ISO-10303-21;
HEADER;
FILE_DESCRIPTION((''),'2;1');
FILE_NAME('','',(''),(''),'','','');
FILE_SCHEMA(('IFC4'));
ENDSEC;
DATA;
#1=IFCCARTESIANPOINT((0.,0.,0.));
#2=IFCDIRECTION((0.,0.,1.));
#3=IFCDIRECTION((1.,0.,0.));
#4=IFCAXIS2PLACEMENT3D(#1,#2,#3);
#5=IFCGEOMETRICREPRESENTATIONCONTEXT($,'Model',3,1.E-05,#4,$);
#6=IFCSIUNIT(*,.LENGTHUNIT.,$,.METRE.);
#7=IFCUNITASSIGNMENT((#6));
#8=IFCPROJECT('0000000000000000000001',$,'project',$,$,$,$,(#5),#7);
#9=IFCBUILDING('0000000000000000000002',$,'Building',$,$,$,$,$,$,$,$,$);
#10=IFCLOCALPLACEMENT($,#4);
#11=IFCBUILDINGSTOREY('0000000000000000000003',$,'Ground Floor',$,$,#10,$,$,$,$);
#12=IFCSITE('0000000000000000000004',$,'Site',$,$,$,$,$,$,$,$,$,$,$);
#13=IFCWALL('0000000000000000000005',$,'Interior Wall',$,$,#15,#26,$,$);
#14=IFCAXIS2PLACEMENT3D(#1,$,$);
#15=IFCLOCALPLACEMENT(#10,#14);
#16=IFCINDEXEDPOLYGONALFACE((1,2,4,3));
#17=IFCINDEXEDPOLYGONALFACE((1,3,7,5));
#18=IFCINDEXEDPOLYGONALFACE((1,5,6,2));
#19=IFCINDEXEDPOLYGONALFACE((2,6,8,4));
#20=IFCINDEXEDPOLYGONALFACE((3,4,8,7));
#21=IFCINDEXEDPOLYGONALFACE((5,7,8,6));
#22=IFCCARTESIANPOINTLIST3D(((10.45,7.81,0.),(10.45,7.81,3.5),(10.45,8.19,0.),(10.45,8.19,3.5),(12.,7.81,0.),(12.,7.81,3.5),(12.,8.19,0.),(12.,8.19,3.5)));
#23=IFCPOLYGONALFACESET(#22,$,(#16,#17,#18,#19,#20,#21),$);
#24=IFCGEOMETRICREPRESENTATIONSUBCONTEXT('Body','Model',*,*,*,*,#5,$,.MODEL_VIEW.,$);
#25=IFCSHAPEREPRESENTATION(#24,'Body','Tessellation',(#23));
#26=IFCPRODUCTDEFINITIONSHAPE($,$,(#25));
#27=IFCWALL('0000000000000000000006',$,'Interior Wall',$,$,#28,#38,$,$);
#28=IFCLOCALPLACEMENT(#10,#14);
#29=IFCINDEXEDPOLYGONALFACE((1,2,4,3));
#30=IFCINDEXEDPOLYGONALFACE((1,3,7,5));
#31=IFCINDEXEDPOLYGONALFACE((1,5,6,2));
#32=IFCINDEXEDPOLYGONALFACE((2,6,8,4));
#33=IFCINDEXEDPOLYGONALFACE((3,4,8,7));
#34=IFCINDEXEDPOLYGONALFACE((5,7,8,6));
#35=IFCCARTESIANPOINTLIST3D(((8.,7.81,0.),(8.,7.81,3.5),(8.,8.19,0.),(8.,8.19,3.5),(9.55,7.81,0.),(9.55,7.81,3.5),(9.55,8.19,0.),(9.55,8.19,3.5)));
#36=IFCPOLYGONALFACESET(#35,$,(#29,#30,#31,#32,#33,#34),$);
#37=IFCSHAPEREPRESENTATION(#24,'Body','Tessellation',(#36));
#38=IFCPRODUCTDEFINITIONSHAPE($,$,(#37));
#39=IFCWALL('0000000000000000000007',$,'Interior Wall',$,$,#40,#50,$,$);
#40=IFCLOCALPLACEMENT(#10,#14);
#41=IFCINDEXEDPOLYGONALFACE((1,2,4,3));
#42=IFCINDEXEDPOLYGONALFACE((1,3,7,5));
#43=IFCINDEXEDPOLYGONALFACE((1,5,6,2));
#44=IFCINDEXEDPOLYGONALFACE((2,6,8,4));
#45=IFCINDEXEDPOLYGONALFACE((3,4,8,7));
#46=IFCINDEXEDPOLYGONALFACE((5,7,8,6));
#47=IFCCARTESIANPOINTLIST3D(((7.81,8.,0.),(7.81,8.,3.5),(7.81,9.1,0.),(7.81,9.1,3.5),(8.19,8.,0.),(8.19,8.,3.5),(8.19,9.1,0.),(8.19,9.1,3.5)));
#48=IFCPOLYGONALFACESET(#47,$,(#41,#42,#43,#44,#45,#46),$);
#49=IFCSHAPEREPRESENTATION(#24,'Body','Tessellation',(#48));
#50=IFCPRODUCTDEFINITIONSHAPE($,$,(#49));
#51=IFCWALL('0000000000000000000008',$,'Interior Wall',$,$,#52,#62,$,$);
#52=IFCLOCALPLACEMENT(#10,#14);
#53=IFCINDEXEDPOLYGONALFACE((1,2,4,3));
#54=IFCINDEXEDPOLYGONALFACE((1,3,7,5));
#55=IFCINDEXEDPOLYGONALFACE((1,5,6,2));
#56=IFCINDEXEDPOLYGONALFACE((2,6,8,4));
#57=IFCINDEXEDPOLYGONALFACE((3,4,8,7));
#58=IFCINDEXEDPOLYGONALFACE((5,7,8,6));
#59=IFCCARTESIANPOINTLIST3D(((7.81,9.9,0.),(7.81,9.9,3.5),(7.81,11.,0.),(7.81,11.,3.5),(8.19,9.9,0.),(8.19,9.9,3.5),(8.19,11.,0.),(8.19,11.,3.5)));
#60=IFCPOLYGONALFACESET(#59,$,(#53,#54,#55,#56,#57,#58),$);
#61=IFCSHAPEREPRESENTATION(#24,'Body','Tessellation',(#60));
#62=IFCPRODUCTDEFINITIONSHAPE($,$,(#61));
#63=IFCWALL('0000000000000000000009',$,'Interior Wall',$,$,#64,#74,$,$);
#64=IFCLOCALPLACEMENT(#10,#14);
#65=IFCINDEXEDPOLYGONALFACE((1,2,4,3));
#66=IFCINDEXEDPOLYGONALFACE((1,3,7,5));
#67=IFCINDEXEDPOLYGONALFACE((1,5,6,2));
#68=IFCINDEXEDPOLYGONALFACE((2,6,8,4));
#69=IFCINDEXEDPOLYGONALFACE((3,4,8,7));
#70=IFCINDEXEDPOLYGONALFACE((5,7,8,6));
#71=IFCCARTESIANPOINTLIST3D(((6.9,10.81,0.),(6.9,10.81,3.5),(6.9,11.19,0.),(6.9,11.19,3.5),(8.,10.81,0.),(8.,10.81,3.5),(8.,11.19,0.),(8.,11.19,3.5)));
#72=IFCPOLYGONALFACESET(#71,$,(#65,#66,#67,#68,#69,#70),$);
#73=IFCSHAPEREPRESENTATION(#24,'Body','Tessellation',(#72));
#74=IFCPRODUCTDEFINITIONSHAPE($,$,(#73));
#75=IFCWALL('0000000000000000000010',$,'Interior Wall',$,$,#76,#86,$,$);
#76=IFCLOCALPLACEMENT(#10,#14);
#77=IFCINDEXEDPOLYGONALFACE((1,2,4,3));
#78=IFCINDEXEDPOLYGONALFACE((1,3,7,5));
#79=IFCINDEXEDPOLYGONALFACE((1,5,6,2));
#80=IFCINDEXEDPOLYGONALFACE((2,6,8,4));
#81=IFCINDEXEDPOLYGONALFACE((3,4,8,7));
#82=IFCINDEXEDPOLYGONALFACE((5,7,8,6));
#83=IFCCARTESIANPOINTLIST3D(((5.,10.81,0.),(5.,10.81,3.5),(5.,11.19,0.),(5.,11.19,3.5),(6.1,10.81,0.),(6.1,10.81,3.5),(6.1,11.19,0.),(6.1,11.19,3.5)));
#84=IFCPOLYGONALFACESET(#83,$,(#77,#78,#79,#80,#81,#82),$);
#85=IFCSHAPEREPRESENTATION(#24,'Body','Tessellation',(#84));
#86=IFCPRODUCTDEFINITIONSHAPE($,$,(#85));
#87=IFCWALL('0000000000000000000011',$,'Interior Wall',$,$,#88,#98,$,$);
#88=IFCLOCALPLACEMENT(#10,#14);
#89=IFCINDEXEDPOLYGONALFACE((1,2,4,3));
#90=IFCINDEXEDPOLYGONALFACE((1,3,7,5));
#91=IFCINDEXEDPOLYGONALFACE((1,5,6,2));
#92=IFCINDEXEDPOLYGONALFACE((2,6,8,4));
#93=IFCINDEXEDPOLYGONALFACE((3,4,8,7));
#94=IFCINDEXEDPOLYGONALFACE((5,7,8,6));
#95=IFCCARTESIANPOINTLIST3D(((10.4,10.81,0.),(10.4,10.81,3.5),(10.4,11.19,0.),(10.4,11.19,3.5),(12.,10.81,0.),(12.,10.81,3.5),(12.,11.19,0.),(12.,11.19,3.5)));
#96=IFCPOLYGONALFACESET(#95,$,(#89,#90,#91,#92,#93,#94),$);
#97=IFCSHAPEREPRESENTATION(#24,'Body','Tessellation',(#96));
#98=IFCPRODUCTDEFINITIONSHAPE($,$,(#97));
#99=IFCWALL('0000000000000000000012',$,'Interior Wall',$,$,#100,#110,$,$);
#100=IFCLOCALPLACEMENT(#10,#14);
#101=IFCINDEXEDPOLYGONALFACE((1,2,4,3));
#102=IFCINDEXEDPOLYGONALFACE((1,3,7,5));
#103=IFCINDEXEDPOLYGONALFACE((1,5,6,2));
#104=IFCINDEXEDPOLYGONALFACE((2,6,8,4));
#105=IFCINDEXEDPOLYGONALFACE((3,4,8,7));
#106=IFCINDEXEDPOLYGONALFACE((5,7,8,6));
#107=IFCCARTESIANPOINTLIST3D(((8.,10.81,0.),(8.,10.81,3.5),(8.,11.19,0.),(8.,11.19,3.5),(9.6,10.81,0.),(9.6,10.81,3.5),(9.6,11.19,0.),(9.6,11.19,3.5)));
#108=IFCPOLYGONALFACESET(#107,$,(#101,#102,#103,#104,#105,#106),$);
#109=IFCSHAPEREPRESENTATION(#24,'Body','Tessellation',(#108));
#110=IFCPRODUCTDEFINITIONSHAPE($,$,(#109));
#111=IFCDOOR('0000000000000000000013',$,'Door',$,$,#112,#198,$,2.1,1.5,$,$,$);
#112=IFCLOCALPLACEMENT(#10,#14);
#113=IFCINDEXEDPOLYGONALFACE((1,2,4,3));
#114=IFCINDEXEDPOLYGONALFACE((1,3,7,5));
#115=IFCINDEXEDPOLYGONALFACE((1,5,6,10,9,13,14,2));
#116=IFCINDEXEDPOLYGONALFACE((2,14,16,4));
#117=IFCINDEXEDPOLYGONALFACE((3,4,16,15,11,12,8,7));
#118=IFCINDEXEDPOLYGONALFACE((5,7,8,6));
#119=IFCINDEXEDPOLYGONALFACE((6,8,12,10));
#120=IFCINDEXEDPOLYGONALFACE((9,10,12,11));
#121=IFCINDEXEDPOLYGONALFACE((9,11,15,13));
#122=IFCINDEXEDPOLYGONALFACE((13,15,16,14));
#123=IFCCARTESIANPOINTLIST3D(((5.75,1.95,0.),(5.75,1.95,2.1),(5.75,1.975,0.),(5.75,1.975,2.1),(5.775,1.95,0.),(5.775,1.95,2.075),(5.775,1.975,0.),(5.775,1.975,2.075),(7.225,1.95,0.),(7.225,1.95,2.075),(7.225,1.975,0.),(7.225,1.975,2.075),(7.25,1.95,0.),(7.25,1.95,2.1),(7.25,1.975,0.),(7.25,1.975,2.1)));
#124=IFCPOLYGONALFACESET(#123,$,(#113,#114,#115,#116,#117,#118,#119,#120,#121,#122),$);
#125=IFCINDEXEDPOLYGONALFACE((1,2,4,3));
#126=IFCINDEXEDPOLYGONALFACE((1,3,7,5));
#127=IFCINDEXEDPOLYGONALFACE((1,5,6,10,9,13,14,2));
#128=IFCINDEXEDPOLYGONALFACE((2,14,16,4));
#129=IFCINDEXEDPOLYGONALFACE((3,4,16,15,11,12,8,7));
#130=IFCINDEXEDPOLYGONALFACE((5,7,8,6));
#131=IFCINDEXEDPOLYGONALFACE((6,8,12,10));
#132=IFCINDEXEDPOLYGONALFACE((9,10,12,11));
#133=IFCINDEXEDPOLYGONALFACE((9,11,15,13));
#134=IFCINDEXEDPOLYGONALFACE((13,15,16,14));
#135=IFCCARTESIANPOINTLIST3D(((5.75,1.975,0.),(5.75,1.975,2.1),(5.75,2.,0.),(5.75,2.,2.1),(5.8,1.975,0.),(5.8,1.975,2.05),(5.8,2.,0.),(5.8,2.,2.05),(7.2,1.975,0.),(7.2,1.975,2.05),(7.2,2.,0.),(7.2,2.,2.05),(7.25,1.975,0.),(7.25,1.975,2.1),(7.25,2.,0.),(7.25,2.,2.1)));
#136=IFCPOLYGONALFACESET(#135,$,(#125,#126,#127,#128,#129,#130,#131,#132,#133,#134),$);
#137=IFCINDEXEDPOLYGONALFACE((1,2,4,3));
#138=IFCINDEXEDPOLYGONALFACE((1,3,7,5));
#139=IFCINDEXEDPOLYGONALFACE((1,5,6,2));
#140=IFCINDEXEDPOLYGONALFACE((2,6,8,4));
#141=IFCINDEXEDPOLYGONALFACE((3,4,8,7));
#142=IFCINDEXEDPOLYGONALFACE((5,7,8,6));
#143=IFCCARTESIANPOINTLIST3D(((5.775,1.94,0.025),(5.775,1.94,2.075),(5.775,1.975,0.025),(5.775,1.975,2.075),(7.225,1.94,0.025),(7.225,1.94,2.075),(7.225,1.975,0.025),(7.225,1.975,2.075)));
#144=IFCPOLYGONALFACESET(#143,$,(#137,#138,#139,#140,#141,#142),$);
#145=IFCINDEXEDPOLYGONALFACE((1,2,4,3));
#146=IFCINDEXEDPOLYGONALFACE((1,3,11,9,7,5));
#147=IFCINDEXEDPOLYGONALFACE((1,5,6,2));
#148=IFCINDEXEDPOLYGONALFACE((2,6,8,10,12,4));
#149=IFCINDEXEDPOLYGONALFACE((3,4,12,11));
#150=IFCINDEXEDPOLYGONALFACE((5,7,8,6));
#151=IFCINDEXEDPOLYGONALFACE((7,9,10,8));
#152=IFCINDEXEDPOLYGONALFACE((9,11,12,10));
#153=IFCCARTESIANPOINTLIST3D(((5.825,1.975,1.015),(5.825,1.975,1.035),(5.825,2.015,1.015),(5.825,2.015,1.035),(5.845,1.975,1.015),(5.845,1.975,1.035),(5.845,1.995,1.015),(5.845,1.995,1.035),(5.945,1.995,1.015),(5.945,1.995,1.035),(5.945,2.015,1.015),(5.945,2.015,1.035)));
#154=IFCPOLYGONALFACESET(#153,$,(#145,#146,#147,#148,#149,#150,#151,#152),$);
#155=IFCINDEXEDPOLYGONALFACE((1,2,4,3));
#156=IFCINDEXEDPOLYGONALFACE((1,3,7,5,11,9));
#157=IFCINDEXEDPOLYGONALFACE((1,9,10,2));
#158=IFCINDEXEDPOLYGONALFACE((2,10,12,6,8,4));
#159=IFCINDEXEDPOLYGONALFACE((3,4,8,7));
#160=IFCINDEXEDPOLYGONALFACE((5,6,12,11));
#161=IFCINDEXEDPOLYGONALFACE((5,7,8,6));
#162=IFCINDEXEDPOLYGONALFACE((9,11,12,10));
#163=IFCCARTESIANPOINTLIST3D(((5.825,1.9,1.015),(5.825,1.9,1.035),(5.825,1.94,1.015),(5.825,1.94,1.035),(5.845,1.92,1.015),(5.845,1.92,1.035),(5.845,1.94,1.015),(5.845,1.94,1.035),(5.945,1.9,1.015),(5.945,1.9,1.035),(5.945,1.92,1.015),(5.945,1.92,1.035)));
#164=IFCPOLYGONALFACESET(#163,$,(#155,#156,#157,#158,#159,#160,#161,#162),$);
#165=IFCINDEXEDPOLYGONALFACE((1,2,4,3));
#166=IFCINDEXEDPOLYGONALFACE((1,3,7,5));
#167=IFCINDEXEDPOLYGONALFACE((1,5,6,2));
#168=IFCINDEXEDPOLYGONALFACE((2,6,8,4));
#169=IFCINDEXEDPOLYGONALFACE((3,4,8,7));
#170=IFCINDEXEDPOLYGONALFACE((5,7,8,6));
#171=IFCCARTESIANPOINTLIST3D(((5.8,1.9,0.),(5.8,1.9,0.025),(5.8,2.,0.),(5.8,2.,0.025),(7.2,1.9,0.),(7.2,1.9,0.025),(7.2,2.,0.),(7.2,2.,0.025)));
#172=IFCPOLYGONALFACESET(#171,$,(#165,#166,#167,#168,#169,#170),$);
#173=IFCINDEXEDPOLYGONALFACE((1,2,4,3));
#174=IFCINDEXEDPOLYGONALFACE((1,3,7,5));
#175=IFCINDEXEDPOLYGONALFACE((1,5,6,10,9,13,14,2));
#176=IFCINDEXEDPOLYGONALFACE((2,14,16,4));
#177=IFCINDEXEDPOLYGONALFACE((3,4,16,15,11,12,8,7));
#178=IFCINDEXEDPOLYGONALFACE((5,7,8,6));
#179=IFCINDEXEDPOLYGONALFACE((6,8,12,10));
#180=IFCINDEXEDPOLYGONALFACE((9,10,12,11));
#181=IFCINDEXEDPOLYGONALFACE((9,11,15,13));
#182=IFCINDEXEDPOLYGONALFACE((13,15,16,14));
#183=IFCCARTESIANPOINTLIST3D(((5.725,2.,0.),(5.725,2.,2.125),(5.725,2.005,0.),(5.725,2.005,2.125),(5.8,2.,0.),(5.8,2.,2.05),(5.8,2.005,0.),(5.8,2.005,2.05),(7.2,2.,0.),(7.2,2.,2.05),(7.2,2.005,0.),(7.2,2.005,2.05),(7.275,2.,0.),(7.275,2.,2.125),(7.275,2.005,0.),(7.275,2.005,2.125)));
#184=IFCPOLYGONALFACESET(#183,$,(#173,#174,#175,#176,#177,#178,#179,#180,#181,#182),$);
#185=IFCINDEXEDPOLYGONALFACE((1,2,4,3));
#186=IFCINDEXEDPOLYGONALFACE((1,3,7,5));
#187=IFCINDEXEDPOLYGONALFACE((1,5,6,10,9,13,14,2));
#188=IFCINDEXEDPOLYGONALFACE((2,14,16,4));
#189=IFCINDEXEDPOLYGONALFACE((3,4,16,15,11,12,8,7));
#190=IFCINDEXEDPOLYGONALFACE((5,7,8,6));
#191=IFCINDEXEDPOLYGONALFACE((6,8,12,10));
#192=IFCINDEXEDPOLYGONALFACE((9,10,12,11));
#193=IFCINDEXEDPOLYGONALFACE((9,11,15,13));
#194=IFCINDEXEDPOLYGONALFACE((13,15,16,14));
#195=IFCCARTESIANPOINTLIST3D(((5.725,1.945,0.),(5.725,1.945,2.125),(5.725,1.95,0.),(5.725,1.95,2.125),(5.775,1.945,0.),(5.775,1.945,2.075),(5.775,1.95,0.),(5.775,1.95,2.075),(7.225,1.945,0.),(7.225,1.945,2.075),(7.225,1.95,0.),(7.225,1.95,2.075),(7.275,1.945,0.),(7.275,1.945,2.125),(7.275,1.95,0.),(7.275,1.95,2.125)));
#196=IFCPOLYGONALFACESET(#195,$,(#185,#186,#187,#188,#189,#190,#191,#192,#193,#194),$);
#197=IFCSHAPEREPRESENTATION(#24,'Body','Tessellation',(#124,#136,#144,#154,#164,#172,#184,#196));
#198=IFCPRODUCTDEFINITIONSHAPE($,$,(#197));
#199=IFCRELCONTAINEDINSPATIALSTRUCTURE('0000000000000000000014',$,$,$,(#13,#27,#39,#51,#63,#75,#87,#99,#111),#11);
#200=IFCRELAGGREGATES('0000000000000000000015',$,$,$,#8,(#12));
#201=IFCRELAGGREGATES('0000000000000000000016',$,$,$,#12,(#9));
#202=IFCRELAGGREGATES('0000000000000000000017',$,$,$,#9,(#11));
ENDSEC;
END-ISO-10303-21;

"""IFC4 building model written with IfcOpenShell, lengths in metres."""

from ifc_helpers import new_model, si_unit, frame, origin_with_axes, place, context, subcontext, project, spatial, line, indexed_curve, outline, extrude, element, save


model = new_model("IFC4")

# Units and contexts
model_context = context("Model", 3, precision=1e-05, world=origin_with_axes())
body_context = subcontext(model_context, "Body", "Model", "MODEL_VIEW")
ifc_project = project(units=[si_unit("LENGTHUNIT", "METRE")], contexts=[model_context])

# Site, building, storey
site = spatial("IfcSite", under=ifc_project, Name="Site")
building = spatial("IfcBuilding", under=site, Name="Building")
storey_placement = place(None, origin_with_axes())
storey = spatial("IfcBuildingStorey", under=building, at=storey_placement, Name="Ground Floor")

# Walls
for number, where, z_axis, x_axis, name in (
    (1, (12.0, 8.0, 0.0), (0.0, 0.0, 1.0), (-1.0, 0.0, 0.0), "Interior Wall"),
    (2, (9.55, 8.0, 0.0), (0.0, 0.0, 1.0), (-1.0, 0.0, 0.0), "Interior Wall"),
):
    element("IfcWall", number, at=place(storey_placement, frame(where, z_axis=z_axis, x_axis=x_axis)), inside=storey, Name=name, context=body_context, shape_type="SweptSolid", body=[
        extrude(outline(indexed_curve([(0.0, 0.0), (0.0, 0.38), (1.55, 0.38), (1.55, 0.0), (0.0, 0.0)], self_intersect=False)), frame((0.0, -0.19, 0.0), z_axis=(0.0, 0.0, 1.0), x_axis=(1.0, 0.0, 0.0)), (0.0, 0.0, 1.0), 3.5),
    ])
for number, where, z_axis, x_axis, name in (
    (3, (8.0, 8.0, 0.0), (0.0, 0.0, 1.0), (0.0, 1.0, 0.0), "Interior Wall"),
    (4, (8.0, 9.9, 0.0), (0.0, 0.0, 1.0), (0.0, 1.0, 0.0), "Interior Wall"),
    (5, (8.0, 11.0, 0.0), (0.0, 0.0, 1.0), (-1.0, 0.0, 0.0), "Interior Wall"),
    (6, (6.1, 11.0, 0.0), (0.0, 0.0, 1.0), (-1.0, 0.0, 0.0), "Interior Wall"),
):
    element("IfcWall", number, at=place(storey_placement, frame(where, z_axis=z_axis, x_axis=x_axis)), inside=storey, Name=name, context=body_context, shape_type="SweptSolid", body=[
        extrude(outline(indexed_curve([(0.0, 0.0), (0.0, 0.38), (1.1, 0.38), (1.1, 0.0), (0.0, 0.0)], self_intersect=False)), frame((0.0, -0.19, 0.0), z_axis=(0.0, 0.0, 1.0), x_axis=(1.0, 0.0, 0.0)), (0.0, 0.0, 1.0), 3.5),
    ])
for number, where, z_axis, x_axis, name in (
    (7, (12.0, 11.0, 0.0), (0.0, 0.0, 1.0), (-1.0, 0.0, 0.0), "Interior Wall"),
    (8, (9.6, 11.0, 0.0), (0.0, 0.0, 1.0), (-1.0, 0.0, 0.0), "Interior Wall"),
):
    element("IfcWall", number, at=place(storey_placement, frame(where, z_axis=z_axis, x_axis=x_axis)), inside=storey, Name=name, context=body_context, shape_type="SweptSolid", body=[
        extrude(outline(indexed_curve([(0.0, 0.0), (0.0, 0.38), (1.6, 0.38), (1.6, 0.0), (0.0, 0.0)], self_intersect=False)), frame((0.0, -0.19, 0.0), z_axis=(0.0, 0.0, 1.0), x_axis=(1.0, 0.0, 0.0)), (0.0, 0.0, 1.0), 3.5),
    ])

# Door
door_1_placement = place(storey_placement, frame((7.25, 2.0, 0.0), z_axis=(0.0, 0.0, 1.0), x_axis=(-1.0, 0.0, 0.0)))
element("IfcDoor", 9, at=door_1_placement, inside=storey, Name="Door", OverallHeight=2.1, OverallWidth=1.5, context=body_context, shape_type="SweptSolid", body=[
    extrude(outline(indexed_curve([(0.0, 0.0), (0.0, 2.1), (1.5, 2.1), (1.5, 0.0), (1.475, 0.0), (1.475, 2.075), (0.025, 2.075), (0.025, 0.0)], segments=[line(1, 2, 3, 4, 5, 6, 7, 8, 1)])), frame((0.0, 0.025, 0.0), z_axis=(0.0, -1.0, 0.0), x_axis=(1.0, 0.0, 0.0)), (0.0, 0.0, -1.0), 0.025),
    extrude(outline(indexed_curve([(0.0, 0.0), (0.0, 2.1), (1.5, 2.1), (1.5, 0.0), (1.45, 0.0), (1.45, 2.05), (0.05, 2.05), (0.05, 0.0)], segments=[line(1, 2, 3, 4, 5, 6, 7, 8, 1)])), frame((0.0, 0.0, 0.0), z_axis=(0.0, -1.0, 0.0), x_axis=(1.0, 0.0, 0.0)), (0.0, 0.0, -1.0), 0.025),
    extrude(outline(indexed_curve([(0.0, 0.0), (1.45, 0.0), (1.45, 0.035), (0.0, 0.035)], segments=[line(1, 2, 3, 4, 1)])), frame((0.025, 0.025, 0.025), z_axis=(0.0, 0.0, 1.0), x_axis=(1.0, 0.0, 0.0)), (0.0, 0.0, 1.0), 2.05),
    extrude(outline(indexed_curve([(0.0, 0.0), (0.0, -0.04), (-0.12, -0.04), (-0.12, -0.02), (-0.02, -0.02), (-0.02, 0.0)], segments=[line(1, 2, 3, 4, 5, 6, 1)])), frame((1.425, 0.025, 1.015), z_axis=(0.0, 0.0, 1.0), x_axis=(1.0, 0.0, 0.0)), (0.0, 0.0, 1.0), 0.02),
    extrude(outline(indexed_curve([(0.0, 0.0), (0.0, 0.04), (-0.12, 0.04), (-0.12, 0.02), (-0.02, 0.02), (-0.02, 0.0)], segments=[line(1, 2, 3, 4, 5, 6, 1)])), frame((1.425, 0.06, 1.015), z_axis=(0.0, 0.0, 1.0), x_axis=(1.0, 0.0, 0.0)), (0.0, 0.0, 1.0), 0.02),
    extrude(outline(indexed_curve([(0.0, 0.0), (1.4, 0.0), (1.4, 0.1), (0.0, 0.1)], segments=[line(1, 2, 3, 4, 1)])), frame((0.05, 0.0, 0.0), z_axis=(0.0, 0.0, 1.0), x_axis=(1.0, 0.0, 0.0)), (0.0, 0.0, 1.0), 0.025),
    extrude(outline(indexed_curve([(0.0, 0.0), (0.0, 2.125), (1.55, 2.125), (1.55, 0.0), (1.475, 0.0), (1.475, 2.05), (0.075, 2.05), (0.075, 0.0)], segments=[line(1, 2, 3, 4, 5, 6, 7, 8, 1)])), frame((-0.025, -0.005, 0.0), z_axis=(0.0, -1.0, 0.0), x_axis=(1.0, 0.0, 0.0)), (0.0, 0.0, -1.0), 0.005),
    extrude(outline(indexed_curve([(0.0, 0.0), (0.0, 2.125), (1.55, 2.125), (1.55, 0.0), (1.5, 0.0), (1.5, 2.075), (0.05, 2.075), (0.05, 0.0)], segments=[line(1, 2, 3, 4, 5, 6, 7, 8, 1)])), frame((-0.025, 0.05, 0.0), z_axis=(0.0, -1.0, 0.0), x_axis=(1.0, 0.0, 0.0)), (0.0, 0.0, -1.0), 0.005),
])

save(model, "model.ifc")
